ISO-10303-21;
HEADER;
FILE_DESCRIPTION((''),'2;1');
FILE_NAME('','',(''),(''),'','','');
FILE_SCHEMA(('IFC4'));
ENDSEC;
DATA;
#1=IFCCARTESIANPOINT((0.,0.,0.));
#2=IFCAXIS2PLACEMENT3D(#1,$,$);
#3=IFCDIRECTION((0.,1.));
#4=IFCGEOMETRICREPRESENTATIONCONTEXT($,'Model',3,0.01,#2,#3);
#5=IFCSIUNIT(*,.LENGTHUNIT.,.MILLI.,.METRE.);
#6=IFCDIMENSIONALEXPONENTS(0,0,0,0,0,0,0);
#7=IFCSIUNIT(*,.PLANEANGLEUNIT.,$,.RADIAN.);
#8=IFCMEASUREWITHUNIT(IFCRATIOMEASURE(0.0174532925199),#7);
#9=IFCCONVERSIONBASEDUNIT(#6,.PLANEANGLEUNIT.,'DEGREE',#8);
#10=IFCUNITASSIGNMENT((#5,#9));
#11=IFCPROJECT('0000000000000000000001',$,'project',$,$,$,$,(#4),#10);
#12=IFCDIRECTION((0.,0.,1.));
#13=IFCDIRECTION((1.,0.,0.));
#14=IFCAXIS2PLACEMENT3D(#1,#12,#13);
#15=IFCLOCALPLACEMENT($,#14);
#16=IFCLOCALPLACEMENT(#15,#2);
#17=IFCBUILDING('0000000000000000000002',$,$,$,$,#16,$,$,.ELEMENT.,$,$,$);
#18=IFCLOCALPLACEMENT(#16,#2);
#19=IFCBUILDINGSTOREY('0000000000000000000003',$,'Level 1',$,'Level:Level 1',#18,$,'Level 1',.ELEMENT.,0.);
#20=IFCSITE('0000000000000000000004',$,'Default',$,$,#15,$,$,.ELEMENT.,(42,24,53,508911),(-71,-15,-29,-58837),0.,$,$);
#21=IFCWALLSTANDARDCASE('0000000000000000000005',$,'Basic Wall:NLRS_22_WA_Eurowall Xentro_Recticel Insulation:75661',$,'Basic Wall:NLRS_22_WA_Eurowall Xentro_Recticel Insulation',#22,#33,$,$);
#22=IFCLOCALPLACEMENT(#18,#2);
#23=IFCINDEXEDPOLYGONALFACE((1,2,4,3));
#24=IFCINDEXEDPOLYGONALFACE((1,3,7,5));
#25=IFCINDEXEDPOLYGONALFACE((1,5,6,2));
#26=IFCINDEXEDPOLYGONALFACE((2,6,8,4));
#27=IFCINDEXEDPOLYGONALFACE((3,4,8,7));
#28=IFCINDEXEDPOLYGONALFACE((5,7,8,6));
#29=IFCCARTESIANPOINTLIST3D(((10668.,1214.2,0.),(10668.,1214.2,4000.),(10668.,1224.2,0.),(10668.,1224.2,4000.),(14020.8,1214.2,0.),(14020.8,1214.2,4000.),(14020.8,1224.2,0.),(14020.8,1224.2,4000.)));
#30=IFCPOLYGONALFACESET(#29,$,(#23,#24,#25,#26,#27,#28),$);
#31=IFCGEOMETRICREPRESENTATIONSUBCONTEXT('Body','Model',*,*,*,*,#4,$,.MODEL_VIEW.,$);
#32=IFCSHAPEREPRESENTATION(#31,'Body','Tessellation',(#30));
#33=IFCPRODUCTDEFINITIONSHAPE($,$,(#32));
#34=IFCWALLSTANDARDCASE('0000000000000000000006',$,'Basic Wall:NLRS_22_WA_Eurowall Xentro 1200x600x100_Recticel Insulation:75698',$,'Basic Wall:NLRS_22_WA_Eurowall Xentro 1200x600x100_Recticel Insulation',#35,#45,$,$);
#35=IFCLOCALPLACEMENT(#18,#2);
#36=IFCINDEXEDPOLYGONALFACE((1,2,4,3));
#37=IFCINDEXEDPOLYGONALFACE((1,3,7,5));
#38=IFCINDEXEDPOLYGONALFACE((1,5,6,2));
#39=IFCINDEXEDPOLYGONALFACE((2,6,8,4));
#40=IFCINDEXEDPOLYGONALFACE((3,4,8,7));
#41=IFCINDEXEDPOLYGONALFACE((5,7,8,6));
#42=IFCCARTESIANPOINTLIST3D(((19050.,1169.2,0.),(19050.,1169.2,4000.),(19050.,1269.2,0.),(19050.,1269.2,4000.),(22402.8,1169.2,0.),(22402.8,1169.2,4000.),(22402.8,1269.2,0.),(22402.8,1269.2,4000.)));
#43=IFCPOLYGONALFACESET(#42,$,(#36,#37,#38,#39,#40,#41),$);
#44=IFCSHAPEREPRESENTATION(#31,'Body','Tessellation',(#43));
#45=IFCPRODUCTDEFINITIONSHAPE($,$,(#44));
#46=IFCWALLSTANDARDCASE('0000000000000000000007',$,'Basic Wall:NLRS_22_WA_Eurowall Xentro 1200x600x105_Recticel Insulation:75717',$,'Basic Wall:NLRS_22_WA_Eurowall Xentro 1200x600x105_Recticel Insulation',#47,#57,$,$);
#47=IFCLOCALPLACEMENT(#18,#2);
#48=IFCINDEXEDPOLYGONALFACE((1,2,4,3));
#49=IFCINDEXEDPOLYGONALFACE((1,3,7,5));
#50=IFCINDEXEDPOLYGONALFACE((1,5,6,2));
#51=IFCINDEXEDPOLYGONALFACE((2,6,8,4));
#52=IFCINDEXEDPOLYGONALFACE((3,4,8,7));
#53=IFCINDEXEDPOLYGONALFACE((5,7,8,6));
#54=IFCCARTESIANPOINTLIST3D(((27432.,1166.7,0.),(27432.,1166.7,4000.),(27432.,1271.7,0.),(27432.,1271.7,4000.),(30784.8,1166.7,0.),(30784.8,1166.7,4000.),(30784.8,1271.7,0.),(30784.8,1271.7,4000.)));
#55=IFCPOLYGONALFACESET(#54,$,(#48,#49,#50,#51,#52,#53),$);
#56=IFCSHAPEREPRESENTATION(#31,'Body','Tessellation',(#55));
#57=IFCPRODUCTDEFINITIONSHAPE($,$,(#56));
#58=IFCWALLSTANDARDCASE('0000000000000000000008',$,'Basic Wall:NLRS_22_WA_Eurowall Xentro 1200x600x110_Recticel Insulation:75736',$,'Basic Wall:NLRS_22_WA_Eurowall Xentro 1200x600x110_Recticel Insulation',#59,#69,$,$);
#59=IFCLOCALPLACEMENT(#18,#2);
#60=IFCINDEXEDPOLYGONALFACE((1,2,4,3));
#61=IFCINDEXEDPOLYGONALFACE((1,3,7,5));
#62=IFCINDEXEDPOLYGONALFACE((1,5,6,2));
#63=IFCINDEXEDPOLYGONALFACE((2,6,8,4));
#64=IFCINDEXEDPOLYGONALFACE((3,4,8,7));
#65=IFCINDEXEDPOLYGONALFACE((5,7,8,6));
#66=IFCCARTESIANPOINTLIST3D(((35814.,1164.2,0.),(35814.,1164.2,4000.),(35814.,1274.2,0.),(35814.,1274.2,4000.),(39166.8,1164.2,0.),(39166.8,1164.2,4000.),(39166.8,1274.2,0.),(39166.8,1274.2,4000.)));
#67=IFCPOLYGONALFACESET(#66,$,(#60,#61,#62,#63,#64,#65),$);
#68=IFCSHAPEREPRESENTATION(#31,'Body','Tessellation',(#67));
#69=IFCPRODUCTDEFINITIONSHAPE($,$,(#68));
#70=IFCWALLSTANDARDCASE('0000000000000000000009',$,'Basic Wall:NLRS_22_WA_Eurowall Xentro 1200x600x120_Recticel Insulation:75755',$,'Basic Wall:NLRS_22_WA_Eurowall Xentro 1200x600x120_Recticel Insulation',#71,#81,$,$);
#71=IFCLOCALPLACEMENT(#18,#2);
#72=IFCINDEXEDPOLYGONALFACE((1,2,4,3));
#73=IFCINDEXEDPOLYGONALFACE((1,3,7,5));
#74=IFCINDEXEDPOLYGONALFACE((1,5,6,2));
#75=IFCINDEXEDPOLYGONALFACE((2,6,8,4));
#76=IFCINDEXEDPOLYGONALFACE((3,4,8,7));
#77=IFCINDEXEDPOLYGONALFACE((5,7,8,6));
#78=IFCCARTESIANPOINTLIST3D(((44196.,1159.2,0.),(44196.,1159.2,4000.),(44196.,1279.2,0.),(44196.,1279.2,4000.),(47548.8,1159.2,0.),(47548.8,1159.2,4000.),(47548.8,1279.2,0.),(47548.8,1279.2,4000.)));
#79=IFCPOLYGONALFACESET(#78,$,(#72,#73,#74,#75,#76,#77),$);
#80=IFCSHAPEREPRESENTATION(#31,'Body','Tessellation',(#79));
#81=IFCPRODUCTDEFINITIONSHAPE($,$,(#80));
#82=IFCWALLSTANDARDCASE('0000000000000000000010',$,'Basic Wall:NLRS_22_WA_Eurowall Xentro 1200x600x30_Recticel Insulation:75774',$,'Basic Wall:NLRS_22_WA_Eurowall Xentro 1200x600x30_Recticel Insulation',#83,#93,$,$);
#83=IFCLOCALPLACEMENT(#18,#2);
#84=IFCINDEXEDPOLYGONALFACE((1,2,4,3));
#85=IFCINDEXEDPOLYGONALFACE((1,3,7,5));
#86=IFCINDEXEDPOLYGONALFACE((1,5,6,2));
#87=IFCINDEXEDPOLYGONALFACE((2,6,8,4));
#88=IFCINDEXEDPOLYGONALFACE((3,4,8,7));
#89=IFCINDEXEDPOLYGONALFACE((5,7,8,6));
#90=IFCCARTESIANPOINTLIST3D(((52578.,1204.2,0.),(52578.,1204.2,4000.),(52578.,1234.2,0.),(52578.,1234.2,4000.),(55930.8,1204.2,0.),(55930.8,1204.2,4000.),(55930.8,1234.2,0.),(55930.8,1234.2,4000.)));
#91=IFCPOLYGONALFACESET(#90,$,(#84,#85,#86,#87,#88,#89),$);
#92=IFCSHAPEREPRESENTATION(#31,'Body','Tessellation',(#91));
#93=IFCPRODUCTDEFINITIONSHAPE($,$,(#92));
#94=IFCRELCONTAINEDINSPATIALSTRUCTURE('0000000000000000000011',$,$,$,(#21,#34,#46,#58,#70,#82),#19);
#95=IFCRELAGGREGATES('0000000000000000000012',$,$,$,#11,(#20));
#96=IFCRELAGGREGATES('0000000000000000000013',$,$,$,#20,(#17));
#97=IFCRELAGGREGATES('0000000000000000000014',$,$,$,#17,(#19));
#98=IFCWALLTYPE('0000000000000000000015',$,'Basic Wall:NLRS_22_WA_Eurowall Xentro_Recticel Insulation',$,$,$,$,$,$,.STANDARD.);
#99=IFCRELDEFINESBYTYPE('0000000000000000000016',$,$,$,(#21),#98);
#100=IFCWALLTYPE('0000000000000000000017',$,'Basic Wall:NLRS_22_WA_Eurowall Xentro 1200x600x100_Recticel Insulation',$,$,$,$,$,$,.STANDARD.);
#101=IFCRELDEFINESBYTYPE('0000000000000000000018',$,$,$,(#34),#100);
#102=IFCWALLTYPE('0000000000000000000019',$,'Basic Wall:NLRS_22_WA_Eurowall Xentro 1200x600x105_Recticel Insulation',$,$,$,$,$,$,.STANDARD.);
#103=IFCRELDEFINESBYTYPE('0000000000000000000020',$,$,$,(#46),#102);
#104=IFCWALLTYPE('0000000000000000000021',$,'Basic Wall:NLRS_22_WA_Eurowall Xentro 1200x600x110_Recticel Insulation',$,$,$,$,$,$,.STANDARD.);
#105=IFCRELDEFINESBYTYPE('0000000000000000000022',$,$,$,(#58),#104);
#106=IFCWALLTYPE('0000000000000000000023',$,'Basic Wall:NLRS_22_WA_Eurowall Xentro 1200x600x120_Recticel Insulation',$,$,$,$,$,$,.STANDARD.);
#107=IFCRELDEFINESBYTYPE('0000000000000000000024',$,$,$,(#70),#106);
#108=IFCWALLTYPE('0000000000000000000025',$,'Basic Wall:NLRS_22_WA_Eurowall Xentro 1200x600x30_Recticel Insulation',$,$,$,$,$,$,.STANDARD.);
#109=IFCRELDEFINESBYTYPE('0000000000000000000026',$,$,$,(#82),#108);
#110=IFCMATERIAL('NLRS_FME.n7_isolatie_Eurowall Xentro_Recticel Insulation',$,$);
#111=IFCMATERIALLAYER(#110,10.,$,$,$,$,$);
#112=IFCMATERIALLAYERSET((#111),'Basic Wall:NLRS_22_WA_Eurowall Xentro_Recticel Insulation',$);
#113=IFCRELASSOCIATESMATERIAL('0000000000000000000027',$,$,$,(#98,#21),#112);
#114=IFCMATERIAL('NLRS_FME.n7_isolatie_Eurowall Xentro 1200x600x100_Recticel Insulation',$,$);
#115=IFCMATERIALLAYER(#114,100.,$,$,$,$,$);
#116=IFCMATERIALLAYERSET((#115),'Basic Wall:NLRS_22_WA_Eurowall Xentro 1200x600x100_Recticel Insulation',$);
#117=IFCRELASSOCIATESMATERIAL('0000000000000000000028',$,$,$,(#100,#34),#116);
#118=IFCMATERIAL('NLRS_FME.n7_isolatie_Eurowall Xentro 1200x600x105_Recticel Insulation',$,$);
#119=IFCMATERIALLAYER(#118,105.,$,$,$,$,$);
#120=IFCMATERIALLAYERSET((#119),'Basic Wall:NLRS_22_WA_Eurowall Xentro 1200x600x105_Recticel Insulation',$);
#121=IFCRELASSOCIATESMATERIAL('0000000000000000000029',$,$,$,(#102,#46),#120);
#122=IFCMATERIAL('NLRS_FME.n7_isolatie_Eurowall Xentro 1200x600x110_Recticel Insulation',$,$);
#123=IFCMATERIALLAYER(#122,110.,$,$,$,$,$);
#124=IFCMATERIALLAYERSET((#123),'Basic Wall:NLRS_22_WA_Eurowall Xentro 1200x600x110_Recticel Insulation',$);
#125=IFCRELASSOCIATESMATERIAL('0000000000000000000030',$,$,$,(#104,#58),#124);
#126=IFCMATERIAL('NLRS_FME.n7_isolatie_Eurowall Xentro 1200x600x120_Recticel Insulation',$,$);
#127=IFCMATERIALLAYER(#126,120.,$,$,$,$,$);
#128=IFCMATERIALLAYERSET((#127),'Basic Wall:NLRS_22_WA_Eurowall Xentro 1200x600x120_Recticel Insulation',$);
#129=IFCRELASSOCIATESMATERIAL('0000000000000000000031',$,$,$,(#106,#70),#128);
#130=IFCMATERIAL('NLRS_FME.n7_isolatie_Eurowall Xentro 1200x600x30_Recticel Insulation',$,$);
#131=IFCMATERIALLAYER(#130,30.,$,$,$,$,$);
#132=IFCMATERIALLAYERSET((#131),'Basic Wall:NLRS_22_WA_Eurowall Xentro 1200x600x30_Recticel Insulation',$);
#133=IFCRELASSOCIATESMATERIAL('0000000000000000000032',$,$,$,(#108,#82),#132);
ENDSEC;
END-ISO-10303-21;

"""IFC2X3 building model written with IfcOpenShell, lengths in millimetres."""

from ifc_helpers import new_model, entity, si_unit, converted_unit, direction, frame, origin, origin_with_axes, origin_2d_with_axis, place, context, subcontext, project, spatial, rectangle, extrude, material, layer, layer_set, layer_usage, type_object, element, save


model = new_model("IFC2X3")

# Units and contexts
model_context = context("Model", 3, precision=0.01, world=origin(), true_north=direction((0.0, 1.0)))
body_context = subcontext(model_context, "Body", "Model", "MODEL_VIEW")
ifc_project = project(units=[si_unit("LENGTHUNIT", "METRE", prefix="MILLI"), converted_unit("PLANEANGLEUNIT", "DEGREE", entity("IfcRatioMeasure", 0.0174532925199), si_unit("PLANEANGLEUNIT", "RADIAN"), dimensions=[0, 0, 0, 0, 0, 0, 0])], contexts=[model_context])

# Site, building, storey
site_placement = place(None, origin_with_axes())
site = spatial("IfcSite", under=ifc_project, at=site_placement, Name="Default", CompositionType="ELEMENT", RefLatitude=(42, 24, 53, 508911), RefLongitude=(-71, -15, -29, -58837), RefElevation=0.0)
building_placement = place(site_placement, origin())
building = spatial("IfcBuilding", under=site, at=building_placement, CompositionType="ELEMENT")
storey_placement = place(building_placement, origin())
storey = spatial("IfcBuildingStorey", under=building, at=storey_placement, Name="Level 1", ObjectType="Level:Level 1", LongName="Level 1", CompositionType="ELEMENT", Elevation=0.0)

# Walls
ifc_material_1 = material(Name="NLRS_FME.n7_isolatie_Eurowall Xentro_Recticel Insulation")
ifc_layer_1 = layer(ifc_material_1, 10.0)
ifc_layer_set_1 = layer_set([ifc_layer_1], Name="Basic Wall:NLRS_22_WA_Eurowall Xentro_Recticel Insulation")
ifc_layer_usage_1 = layer_usage(ifc_layer_set_1, "AXIS2", "NEGATIVE", 5.0)
wall_type_1 = type_object("IfcWallType", Name="Basic Wall:NLRS_22_WA_Eurowall Xentro_Recticel Insulation", PredefinedType="STANDARD", material=ifc_layer_set_1)
wall_1_placement = place(storey_placement, frame((10668.0, 1219.2, 0.0)))
element("IfcWallStandardCase", 1, at=wall_1_placement, inside=storey, type_object=wall_type_1, material=ifc_layer_usage_1, Name="Basic Wall:NLRS_22_WA_Eurowall Xentro_Recticel Insulation:75661", ObjectType="Basic Wall:NLRS_22_WA_Eurowall Xentro_Recticel Insulation", context=body_context, shape_type="SweptSolid", body=[
    extrude(rectangle(XDim=3352.8, YDim=10.0, at=origin_2d_with_axis()), frame((1676.4, 0.0, 0.0), x_axis=(-1.0, 0.0, 0.0)), (0.0, 0.0, 1.0), 4000.0),
])
ifc_material_2 = material(Name="NLRS_FME.n7_isolatie_Eurowall Xentro 1200x600x100_Recticel Insulation")
ifc_layer_2 = layer(ifc_material_2, 100.0)
ifc_layer_set_2 = layer_set([ifc_layer_2], Name="Basic Wall:NLRS_22_WA_Eurowall Xentro 1200x600x100_Recticel Insulation")
ifc_layer_usage_2 = layer_usage(ifc_layer_set_2, "AXIS2", "NEGATIVE", 50.0)
wall_type_2 = type_object("IfcWallType", Name="Basic Wall:NLRS_22_WA_Eurowall Xentro 1200x600x100_Recticel Insulation", PredefinedType="STANDARD", material=ifc_layer_set_2)
wall_2_placement = place(storey_placement, frame((19050.0, 1219.2, 0.0)))
element("IfcWallStandardCase", 2, at=wall_2_placement, inside=storey, type_object=wall_type_2, material=ifc_layer_usage_2, Name="Basic Wall:NLRS_22_WA_Eurowall Xentro 1200x600x100_Recticel Insulation:75698", ObjectType="Basic Wall:NLRS_22_WA_Eurowall Xentro 1200x600x100_Recticel Insulation", context=body_context, shape_type="SweptSolid", body=[
    extrude(rectangle(XDim=3352.8, YDim=100.0, at=origin_2d_with_axis()), frame((1676.4, 0.0, 0.0), x_axis=(-1.0, 0.0, 0.0)), (0.0, 0.0, 1.0), 4000.0),
])
ifc_material_3 = material(Name="NLRS_FME.n7_isolatie_Eurowall Xentro 1200x600x105_Recticel Insulation")
ifc_layer_3 = layer(ifc_material_3, 105.0)
ifc_layer_set_3 = layer_set([ifc_layer_3], Name="Basic Wall:NLRS_22_WA_Eurowall Xentro 1200x600x105_Recticel Insulation")
ifc_layer_usage_3 = layer_usage(ifc_layer_set_3, "AXIS2", "NEGATIVE", 52.5)
wall_type_3 = type_object("IfcWallType", Name="Basic Wall:NLRS_22_WA_Eurowall Xentro 1200x600x105_Recticel Insulation", PredefinedType="STANDARD", material=ifc_layer_set_3)
wall_3_placement = place(storey_placement, frame((27432.0, 1219.2, 0.0)))
element("IfcWallStandardCase", 3, at=wall_3_placement, inside=storey, type_object=wall_type_3, material=ifc_layer_usage_3, Name="Basic Wall:NLRS_22_WA_Eurowall Xentro 1200x600x105_Recticel Insulation:75717", ObjectType="Basic Wall:NLRS_22_WA_Eurowall Xentro 1200x600x105_Recticel Insulation", context=body_context, shape_type="SweptSolid", body=[
    extrude(rectangle(XDim=3352.8, YDim=105.0, at=origin_2d_with_axis()), frame((1676.4, 0.0, 0.0), x_axis=(-1.0, 0.0, 0.0)), (0.0, 0.0, 1.0), 4000.0),
])
ifc_material_4 = material(Name="NLRS_FME.n7_isolatie_Eurowall Xentro 1200x600x110_Recticel Insulation")
ifc_layer_4 = layer(ifc_material_4, 110.0)
ifc_layer_set_4 = layer_set([ifc_layer_4], Name="Basic Wall:NLRS_22_WA_Eurowall Xentro 1200x600x110_Recticel Insulation")
ifc_layer_usage_4 = layer_usage(ifc_layer_set_4, "AXIS2", "NEGATIVE", 55.0)
wall_type_4 = type_object("IfcWallType", Name="Basic Wall:NLRS_22_WA_Eurowall Xentro 1200x600x110_Recticel Insulation", PredefinedType="STANDARD", material=ifc_layer_set_4)
wall_4_placement = place(storey_placement, frame((35814.0, 1219.2, 0.0)))
element("IfcWallStandardCase", 4, at=wall_4_placement, inside=storey, type_object=wall_type_4, material=ifc_layer_usage_4, Name="Basic Wall:NLRS_22_WA_Eurowall Xentro 1200x600x110_Recticel Insulation:75736", ObjectType="Basic Wall:NLRS_22_WA_Eurowall Xentro 1200x600x110_Recticel Insulation", context=body_context, shape_type="SweptSolid", body=[
    extrude(rectangle(XDim=3352.8, YDim=110.0, at=origin_2d_with_axis()), frame((1676.4, 0.0, 0.0), x_axis=(-1.0, 0.0, 0.0)), (0.0, 0.0, 1.0), 4000.0),
])
ifc_material_5 = material(Name="NLRS_FME.n7_isolatie_Eurowall Xentro 1200x600x120_Recticel Insulation")
ifc_layer_5 = layer(ifc_material_5, 120.0)
ifc_layer_set_5 = layer_set([ifc_layer_5], Name="Basic Wall:NLRS_22_WA_Eurowall Xentro 1200x600x120_Recticel Insulation")
ifc_layer_usage_5 = layer_usage(ifc_layer_set_5, "AXIS2", "NEGATIVE", 60.0)
wall_type_5 = type_object("IfcWallType", Name="Basic Wall:NLRS_22_WA_Eurowall Xentro 1200x600x120_Recticel Insulation", PredefinedType="STANDARD", material=ifc_layer_set_5)
wall_5_placement = place(storey_placement, frame((44196.0, 1219.2, 0.0)))
element("IfcWallStandardCase", 5, at=wall_5_placement, inside=storey, type_object=wall_type_5, material=ifc_layer_usage_5, Name="Basic Wall:NLRS_22_WA_Eurowall Xentro 1200x600x120_Recticel Insulation:75755", ObjectType="Basic Wall:NLRS_22_WA_Eurowall Xentro 1200x600x120_Recticel Insulation", context=body_context, shape_type="SweptSolid", body=[
    extrude(rectangle(XDim=3352.8, YDim=120.0, at=origin_2d_with_axis()), frame((1676.4, 0.0, 0.0), x_axis=(-1.0, 0.0, 0.0)), (0.0, 0.0, 1.0), 4000.0),
])
ifc_material_6 = material(Name="NLRS_FME.n7_isolatie_Eurowall Xentro 1200x600x30_Recticel Insulation")
ifc_layer_6 = layer(ifc_material_6, 30.0)
ifc_layer_set_6 = layer_set([ifc_layer_6], Name="Basic Wall:NLRS_22_WA_Eurowall Xentro 1200x600x30_Recticel Insulation")
ifc_layer_usage_6 = layer_usage(ifc_layer_set_6, "AXIS2", "NEGATIVE", 15.0)
wall_type_6 = type_object("IfcWallType", Name="Basic Wall:NLRS_22_WA_Eurowall Xentro 1200x600x30_Recticel Insulation", PredefinedType="STANDARD", material=ifc_layer_set_6)
wall_6_placement = place(storey_placement, frame((52578.0, 1219.2, 0.0)))
element("IfcWallStandardCase", 6, at=wall_6_placement, inside=storey, type_object=wall_type_6, material=ifc_layer_usage_6, Name="Basic Wall:NLRS_22_WA_Eurowall Xentro 1200x600x30_Recticel Insulation:75774", ObjectType="Basic Wall:NLRS_22_WA_Eurowall Xentro 1200x600x30_Recticel Insulation", context=body_context, shape_type="SweptSolid", body=[
    extrude(rectangle(XDim=3352.8, YDim=30.0, at=origin_2d_with_axis()), frame((1676.4, 0.0, 0.0), x_axis=(-1.0, 0.0, 0.0)), (0.0, 0.0, 1.0), 4000.0),
])

save(model, "model.ifc")
